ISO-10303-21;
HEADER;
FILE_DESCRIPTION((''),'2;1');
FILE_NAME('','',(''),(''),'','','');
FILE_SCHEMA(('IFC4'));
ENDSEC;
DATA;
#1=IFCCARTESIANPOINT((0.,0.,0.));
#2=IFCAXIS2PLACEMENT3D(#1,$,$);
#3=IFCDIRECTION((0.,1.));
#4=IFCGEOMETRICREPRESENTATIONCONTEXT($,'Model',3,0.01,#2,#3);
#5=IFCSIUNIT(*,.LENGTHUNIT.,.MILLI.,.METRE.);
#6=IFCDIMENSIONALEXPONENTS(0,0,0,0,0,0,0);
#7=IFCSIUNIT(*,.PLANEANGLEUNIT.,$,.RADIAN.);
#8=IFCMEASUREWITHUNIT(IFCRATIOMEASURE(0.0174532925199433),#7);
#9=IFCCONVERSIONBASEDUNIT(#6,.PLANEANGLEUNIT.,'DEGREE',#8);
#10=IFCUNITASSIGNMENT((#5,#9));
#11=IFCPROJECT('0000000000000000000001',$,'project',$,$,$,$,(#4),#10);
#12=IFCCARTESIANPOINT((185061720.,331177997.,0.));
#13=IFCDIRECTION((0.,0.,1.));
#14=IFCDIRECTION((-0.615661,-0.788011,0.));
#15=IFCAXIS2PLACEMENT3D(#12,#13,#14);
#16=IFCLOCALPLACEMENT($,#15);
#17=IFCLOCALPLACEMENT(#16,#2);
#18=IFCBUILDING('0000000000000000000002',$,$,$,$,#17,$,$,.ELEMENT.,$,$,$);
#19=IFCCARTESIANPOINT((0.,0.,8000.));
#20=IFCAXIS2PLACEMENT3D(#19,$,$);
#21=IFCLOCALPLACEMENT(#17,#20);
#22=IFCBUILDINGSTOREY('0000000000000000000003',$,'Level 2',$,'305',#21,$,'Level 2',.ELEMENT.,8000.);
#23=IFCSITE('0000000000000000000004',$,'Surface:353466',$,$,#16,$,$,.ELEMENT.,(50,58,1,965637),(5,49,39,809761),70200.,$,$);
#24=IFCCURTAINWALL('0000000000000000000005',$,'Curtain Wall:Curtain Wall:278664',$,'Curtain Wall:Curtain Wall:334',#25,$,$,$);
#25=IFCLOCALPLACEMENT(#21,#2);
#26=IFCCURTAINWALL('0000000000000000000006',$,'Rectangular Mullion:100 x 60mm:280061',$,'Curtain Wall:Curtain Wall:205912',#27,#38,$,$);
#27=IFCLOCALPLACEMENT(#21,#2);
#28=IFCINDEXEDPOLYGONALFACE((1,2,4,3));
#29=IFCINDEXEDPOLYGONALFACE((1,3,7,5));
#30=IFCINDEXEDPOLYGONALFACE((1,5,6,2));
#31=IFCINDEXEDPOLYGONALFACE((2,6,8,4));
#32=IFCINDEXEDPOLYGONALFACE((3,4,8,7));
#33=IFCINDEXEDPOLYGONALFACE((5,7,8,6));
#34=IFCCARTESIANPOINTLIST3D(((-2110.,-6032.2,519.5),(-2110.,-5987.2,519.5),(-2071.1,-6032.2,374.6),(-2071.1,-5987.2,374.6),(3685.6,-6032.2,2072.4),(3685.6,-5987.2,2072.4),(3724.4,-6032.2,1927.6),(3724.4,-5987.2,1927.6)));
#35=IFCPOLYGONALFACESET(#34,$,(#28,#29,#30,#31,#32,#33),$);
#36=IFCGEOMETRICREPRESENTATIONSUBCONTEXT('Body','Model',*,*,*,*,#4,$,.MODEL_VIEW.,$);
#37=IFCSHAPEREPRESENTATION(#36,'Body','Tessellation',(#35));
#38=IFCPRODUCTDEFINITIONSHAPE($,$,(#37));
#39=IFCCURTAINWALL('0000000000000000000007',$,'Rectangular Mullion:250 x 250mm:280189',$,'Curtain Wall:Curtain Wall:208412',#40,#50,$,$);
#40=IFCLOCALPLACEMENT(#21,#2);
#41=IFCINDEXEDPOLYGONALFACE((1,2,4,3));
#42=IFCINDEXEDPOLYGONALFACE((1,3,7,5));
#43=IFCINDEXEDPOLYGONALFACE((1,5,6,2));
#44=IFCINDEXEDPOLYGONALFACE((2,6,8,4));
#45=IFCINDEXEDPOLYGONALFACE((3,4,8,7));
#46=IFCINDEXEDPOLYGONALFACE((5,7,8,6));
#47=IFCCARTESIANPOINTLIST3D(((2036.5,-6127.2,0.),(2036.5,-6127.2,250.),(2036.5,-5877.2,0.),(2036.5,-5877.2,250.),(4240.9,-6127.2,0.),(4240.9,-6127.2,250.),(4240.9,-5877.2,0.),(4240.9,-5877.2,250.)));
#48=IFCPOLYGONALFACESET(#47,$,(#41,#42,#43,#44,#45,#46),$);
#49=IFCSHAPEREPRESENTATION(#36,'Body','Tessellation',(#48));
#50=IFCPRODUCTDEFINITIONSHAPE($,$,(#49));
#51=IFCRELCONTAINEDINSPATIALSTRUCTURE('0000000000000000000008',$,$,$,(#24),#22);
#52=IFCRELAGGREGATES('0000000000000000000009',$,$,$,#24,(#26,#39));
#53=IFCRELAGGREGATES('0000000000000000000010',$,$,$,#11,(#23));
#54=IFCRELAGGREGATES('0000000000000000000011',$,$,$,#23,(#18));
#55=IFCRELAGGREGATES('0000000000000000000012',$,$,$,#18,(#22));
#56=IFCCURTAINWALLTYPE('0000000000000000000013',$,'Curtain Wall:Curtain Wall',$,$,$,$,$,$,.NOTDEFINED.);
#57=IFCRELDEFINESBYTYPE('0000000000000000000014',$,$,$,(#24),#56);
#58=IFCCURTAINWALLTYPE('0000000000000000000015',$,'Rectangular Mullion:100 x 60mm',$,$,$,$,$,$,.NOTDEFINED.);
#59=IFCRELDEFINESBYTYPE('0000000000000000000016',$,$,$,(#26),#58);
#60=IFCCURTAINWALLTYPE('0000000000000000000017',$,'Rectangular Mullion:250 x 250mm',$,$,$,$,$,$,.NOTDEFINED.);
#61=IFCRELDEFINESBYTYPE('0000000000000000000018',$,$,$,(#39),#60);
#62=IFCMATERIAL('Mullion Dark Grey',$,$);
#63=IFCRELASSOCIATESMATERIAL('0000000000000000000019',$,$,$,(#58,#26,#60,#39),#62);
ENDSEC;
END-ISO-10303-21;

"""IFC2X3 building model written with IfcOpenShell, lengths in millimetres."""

from ifc_helpers import new_model, entity, si_unit, converted_unit, direction, frame, frame_2d, origin, origin_2d_with_axis, place, context, subcontext, project, spatial, rectangle, extrude, source, transform, mapped, material, type_object, type_shapes, element, aggregate, save


model = new_model("IFC2X3")

# Units and contexts
model_context = context("Model", 3, precision=0.01, world=origin(), true_north=direction((0.0, 1.0)))
body_context = subcontext(model_context, "Body", "Model", "MODEL_VIEW")
ifc_project = project(units=[si_unit("LENGTHUNIT", "METRE", prefix="MILLI"), converted_unit("PLANEANGLEUNIT", "DEGREE", entity("IfcRatioMeasure", 0.0174532925199433), si_unit("PLANEANGLEUNIT", "RADIAN"), dimensions=[0, 0, 0, 0, 0, 0, 0])], contexts=[model_context])

# Site, building, storey
site_placement = place(None, frame((185061720.0, 331177997.0, 0.0), z_axis=(0.0, 0.0, 1.0), x_axis=(-0.615661, -0.788011, 0.0)))
site = spatial("IfcSite", under=ifc_project, at=site_placement, Name="Surface:353466", CompositionType="ELEMENT", RefLatitude=(50, 58, 1, 965637), RefLongitude=(5, 49, 39, 809761), RefElevation=70200.0)
building_placement = place(site_placement, origin())
building = spatial("IfcBuilding", under=site, at=building_placement, CompositionType="ELEMENT")
storey_placement = place(building_placement, frame((0.0, 0.0, 8000.0)))
storey = spatial("IfcBuildingStorey", under=building, at=storey_placement, Name="Level 2", ObjectType="305", LongName="Level 2", CompositionType="ELEMENT", Elevation=8000.0)

# Curtain walls
curtain_wall_type_1 = type_object("IfcCurtainWallType", Name="Curtain Wall:Curtain Wall", PredefinedType="NOTDEFINED")
curtain_wall_1_placement = place(storey_placement, frame((0.0, 0.0, -8000.0)))
curtain_wall_1 = element("IfcCurtainWall", 1, at=curtain_wall_1_placement, inside=storey, type_object=curtain_wall_type_1, Name="Curtain Wall:Curtain Wall:278664", ObjectType="Curtain Wall:Curtain Wall:334")
ifc_material_1 = material(Name="Mullion Dark Grey")
curtain_wall_type_2 = type_object("IfcCurtainWallType", Name="Rectangular Mullion:100 x 60mm", PredefinedType="NOTDEFINED", material=ifc_material_1)
shared_shape_1 = source(origin(), body_context, "Body", "SweptSolid", [
    extrude(rectangle(XDim=45.0, YDim=150.0, at=frame_2d((0.0, 0.0), x_axis=(1.0, 0.0))), frame((0.0, 7.5, -6000.0), z_axis=(0.0, 0.0, 1.0), x_axis=(0.0, -1.0, 0.0)), (0.0, 0.0, 1.0), 6000.0),
])
type_shapes(curtain_wall_type_2, [shared_shape_1])
curtain_wall_2_placement = place(storey_placement, frame((3705.0, -6002.2, 2000.0), z_axis=(0.965926, 0.0, 0.258819), x_axis=(-0.258819, 0.0, 0.965926)))
curtain_wall_2 = element("IfcCurtainWall", 2, at=curtain_wall_2_placement, type_object=curtain_wall_type_2, material=ifc_material_1, Name="Rectangular Mullion:100 x 60mm:280061", ObjectType="Curtain Wall:Curtain Wall:205912", context=body_context, shape_type="MappedRepresentation", body=[
    mapped(shared_shape_1, transform((0.0, 0.0, 0.0), scale=1.0)),
])
curtain_wall_type_3 = type_object("IfcCurtainWallType", Name="Rectangular Mullion:250 x 250mm", PredefinedType="NOTDEFINED", material=ifc_material_1)
shared_shape_2 = source(origin(), body_context, "Body", "SweptSolid", [
    extrude(rectangle(XDim=250.0, YDim=250.0, at=origin_2d_with_axis()), frame((-125.0, 0.0, -2204.4), z_axis=(0.0, 0.0, 1.0), x_axis=(-1.0, 0.0, 0.0)), (0.0, 0.0, 1.0), 2204.4),
])
type_shapes(curtain_wall_type_3, [shared_shape_2])
curtain_wall_3_placement = place(storey_placement, frame((2036.5, -6002.2, 0.0), z_axis=(-1.0, 0.0, 0.0), x_axis=(0.0, 0.0, -1.0)))
curtain_wall_3 = element("IfcCurtainWall", 3, at=curtain_wall_3_placement, type_object=curtain_wall_type_3, material=ifc_material_1, Name="Rectangular Mullion:250 x 250mm:280189", ObjectType="Curtain Wall:Curtain Wall:208412", context=body_context, shape_type="MappedRepresentation", body=[
    mapped(shared_shape_2, transform((0.0, 0.0, 0.0), scale=1.0)),
])
aggregate(curtain_wall_1, [curtain_wall_2, curtain_wall_3])

save(model, "model.ifc")
